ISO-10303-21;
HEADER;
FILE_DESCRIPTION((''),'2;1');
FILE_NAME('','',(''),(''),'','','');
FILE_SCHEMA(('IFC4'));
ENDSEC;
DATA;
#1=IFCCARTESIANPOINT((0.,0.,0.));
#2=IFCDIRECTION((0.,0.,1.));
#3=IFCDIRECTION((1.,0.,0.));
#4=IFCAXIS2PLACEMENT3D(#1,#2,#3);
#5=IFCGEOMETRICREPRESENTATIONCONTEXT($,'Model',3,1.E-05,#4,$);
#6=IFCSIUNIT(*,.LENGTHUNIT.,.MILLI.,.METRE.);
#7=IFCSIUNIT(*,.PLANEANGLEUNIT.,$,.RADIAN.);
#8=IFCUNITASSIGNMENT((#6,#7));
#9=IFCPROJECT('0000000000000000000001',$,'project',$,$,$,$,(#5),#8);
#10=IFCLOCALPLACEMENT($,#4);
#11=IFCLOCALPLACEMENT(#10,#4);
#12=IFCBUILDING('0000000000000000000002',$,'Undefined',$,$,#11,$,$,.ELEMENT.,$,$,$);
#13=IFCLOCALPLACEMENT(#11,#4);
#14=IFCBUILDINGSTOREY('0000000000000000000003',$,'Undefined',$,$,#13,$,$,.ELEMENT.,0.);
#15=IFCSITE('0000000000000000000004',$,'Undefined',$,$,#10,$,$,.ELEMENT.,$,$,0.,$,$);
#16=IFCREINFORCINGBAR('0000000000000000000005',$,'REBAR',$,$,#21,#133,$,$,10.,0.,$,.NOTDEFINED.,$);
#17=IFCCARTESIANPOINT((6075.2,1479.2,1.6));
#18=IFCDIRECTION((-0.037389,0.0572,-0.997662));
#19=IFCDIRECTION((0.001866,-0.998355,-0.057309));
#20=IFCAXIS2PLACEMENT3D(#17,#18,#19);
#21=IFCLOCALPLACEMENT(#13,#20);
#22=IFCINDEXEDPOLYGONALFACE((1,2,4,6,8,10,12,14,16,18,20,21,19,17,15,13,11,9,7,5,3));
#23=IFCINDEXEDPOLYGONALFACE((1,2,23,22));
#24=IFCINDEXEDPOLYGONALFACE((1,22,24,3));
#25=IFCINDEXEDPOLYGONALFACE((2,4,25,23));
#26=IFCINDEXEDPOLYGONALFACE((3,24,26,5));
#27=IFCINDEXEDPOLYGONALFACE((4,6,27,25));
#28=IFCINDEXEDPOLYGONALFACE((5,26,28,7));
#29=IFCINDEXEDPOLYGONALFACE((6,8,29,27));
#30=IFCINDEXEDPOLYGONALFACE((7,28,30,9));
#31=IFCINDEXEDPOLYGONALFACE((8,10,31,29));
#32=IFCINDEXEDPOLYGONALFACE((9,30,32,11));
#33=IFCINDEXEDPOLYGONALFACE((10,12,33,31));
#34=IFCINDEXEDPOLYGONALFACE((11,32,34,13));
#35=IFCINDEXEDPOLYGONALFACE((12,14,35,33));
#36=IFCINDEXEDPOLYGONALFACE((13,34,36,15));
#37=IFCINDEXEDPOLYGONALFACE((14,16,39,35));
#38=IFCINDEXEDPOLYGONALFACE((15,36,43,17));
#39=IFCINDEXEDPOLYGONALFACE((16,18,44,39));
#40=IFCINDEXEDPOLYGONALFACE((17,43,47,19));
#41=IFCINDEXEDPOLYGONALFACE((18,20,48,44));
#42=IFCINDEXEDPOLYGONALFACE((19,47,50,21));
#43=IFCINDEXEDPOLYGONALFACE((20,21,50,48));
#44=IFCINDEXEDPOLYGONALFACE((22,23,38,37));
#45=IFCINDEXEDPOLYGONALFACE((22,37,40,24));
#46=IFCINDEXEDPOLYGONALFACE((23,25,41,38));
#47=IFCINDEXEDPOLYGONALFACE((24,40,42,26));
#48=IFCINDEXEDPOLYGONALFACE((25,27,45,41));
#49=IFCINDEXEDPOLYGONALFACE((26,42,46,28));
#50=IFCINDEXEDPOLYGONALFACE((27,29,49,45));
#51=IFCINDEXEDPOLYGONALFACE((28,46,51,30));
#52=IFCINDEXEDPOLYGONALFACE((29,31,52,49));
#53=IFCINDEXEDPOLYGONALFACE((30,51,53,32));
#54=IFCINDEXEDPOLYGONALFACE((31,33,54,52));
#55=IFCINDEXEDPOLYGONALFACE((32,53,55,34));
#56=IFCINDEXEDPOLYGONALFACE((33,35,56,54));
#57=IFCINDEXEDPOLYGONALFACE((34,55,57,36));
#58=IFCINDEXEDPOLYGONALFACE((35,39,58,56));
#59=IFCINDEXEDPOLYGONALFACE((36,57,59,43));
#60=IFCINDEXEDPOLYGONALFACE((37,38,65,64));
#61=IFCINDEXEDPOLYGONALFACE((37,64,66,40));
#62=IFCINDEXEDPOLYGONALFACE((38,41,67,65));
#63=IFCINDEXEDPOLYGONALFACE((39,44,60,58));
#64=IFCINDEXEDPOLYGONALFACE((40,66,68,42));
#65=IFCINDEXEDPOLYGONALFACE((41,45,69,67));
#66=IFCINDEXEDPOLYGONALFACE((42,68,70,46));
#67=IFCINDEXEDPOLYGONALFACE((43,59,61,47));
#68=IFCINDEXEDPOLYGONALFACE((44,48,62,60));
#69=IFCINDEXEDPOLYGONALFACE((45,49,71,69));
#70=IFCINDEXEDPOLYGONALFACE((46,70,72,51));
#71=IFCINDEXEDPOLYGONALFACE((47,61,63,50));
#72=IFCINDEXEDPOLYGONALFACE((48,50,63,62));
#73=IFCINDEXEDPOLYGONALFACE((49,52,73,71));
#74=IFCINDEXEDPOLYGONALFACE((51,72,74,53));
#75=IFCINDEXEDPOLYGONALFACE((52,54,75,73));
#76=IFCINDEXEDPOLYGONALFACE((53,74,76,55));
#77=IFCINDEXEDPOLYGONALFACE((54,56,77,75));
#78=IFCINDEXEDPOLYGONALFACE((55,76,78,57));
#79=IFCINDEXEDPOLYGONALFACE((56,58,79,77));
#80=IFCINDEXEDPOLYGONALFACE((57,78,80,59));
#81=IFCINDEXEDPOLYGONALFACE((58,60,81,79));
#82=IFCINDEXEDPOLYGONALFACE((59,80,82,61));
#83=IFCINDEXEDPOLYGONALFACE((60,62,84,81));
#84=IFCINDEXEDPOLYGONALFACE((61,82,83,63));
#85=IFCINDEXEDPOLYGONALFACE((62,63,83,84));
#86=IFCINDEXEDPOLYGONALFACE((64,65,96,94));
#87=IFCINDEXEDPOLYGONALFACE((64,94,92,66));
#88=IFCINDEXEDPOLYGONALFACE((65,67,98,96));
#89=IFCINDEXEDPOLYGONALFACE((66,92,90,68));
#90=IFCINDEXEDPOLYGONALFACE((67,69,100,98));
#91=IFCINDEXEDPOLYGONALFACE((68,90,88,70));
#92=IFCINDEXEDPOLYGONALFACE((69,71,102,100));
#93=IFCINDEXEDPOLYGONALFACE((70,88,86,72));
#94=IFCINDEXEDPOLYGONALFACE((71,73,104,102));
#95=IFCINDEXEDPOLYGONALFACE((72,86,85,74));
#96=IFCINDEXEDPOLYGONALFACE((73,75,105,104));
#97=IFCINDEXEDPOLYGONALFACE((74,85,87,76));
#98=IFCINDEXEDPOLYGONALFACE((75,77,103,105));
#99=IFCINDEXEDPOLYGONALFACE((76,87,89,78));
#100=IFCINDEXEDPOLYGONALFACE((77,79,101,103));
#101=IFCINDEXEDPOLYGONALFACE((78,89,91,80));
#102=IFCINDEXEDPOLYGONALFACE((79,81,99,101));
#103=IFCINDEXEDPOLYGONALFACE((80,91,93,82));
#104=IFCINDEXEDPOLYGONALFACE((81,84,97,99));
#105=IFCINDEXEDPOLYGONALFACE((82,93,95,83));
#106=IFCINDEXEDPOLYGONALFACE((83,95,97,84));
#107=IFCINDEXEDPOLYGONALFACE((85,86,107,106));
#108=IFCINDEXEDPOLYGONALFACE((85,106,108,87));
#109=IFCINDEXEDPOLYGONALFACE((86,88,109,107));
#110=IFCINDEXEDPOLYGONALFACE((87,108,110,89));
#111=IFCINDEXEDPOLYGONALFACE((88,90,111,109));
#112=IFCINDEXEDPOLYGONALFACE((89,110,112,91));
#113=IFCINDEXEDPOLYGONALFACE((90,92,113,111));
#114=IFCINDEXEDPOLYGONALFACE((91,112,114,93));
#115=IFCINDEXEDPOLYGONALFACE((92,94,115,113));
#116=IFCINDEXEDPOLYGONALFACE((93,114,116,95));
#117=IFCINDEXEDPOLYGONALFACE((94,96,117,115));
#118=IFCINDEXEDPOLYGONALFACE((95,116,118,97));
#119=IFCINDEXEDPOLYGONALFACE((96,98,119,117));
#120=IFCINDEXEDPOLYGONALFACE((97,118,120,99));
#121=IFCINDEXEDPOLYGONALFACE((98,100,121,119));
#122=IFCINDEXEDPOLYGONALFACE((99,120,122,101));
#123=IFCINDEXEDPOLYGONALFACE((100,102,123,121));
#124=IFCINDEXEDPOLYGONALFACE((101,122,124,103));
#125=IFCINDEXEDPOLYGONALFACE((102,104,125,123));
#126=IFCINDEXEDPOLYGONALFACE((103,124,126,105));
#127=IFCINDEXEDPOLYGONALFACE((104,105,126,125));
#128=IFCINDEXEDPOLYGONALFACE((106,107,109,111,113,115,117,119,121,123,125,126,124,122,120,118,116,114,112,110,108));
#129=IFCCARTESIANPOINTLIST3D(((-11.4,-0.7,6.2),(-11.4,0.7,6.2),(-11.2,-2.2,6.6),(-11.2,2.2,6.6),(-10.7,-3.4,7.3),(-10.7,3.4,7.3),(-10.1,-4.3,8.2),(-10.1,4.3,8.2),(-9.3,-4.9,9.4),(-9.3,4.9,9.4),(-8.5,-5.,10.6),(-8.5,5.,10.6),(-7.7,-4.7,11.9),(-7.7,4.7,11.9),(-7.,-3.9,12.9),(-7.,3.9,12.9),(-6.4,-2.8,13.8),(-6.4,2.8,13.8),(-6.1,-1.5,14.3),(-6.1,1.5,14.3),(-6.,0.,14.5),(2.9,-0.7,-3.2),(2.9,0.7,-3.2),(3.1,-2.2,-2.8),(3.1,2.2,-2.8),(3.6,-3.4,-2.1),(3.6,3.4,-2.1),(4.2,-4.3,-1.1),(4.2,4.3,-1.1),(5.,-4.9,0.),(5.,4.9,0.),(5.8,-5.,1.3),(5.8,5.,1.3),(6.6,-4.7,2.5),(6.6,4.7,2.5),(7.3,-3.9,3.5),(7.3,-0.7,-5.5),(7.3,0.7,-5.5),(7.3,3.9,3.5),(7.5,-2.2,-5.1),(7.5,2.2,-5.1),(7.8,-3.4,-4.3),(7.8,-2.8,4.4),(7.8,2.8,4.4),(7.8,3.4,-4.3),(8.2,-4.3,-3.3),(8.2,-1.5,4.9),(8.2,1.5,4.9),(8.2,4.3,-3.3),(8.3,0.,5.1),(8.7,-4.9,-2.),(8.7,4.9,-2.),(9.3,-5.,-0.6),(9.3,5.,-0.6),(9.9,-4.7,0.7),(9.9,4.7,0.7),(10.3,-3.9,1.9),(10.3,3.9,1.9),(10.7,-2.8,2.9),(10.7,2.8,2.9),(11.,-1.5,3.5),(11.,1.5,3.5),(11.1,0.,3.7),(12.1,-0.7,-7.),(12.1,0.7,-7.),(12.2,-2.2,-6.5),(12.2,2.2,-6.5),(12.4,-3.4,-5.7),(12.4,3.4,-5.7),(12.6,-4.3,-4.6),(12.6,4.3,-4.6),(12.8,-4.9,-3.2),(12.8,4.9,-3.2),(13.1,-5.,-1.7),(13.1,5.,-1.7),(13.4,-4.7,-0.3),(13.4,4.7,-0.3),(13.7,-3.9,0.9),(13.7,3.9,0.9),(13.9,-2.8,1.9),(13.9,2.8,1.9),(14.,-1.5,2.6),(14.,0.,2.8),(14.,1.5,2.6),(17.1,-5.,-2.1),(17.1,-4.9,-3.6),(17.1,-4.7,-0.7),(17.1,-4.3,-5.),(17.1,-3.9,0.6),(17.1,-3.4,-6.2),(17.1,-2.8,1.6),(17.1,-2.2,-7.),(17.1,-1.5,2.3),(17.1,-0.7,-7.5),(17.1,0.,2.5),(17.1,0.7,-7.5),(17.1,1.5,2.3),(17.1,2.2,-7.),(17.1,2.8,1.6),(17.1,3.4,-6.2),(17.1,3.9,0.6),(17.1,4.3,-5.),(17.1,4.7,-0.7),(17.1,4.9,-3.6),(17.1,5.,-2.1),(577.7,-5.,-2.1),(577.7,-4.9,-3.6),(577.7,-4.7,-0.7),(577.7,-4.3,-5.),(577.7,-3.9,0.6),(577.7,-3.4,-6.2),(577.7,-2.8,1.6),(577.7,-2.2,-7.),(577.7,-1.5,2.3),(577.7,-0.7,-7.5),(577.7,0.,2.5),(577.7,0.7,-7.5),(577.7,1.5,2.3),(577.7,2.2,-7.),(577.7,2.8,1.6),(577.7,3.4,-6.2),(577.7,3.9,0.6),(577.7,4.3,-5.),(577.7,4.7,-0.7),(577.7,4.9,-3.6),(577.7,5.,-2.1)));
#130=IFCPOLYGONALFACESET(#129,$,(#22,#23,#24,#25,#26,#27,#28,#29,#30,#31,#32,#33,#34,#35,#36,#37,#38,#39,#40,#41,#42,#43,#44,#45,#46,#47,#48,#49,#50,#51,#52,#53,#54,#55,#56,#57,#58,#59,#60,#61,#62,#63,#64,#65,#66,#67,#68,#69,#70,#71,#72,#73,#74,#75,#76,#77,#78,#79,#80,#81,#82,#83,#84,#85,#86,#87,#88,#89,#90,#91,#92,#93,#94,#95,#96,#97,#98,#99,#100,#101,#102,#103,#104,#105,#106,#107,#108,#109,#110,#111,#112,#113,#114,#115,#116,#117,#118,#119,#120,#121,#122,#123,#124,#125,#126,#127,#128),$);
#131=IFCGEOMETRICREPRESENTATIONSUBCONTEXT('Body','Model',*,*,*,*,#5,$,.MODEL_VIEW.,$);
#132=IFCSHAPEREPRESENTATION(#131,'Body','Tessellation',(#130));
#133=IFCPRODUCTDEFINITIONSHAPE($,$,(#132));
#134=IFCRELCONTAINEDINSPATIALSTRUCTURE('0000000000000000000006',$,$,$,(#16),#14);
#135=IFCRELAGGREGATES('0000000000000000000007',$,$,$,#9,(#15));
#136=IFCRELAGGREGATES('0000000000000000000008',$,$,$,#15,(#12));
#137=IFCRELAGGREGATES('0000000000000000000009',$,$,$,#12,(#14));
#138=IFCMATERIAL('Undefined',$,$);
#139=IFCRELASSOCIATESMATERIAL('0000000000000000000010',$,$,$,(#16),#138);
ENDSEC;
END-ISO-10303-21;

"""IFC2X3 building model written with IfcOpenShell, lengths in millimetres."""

from ifc_helpers import new_model, entity, si_unit, frame, origin_with_axes, place, context, subcontext, project, spatial, source, transform, mapped, material, element, save


model = new_model("IFC2X3")

# Units and contexts
model_context = context("Model", 3, precision=1e-05, world=origin_with_axes())
body_context = subcontext(model_context, "Body", "Model", "MODEL_VIEW")
ifc_project = project(units=[si_unit("LENGTHUNIT", "METRE", prefix="MILLI"), si_unit("PLANEANGLEUNIT", "RADIAN")], contexts=[model_context])

# Site, building, storey
site_placement = place(None, origin_with_axes())
site = spatial("IfcSite", under=ifc_project, at=site_placement, Name="Undefined", CompositionType="ELEMENT", RefElevation=0.0)
building_placement = place(site_placement, origin_with_axes())
building = spatial("IfcBuilding", under=site, at=building_placement, Name="Undefined", CompositionType="ELEMENT")
storey_placement = place(building_placement, origin_with_axes())
storey = spatial("IfcBuildingStorey", under=building, at=storey_placement, Name="Undefined", CompositionType="ELEMENT", Elevation=0.0)

# Reinforcing bar
ifc_material_1 = material(Name="Undefined")
shared_shape_1 = source(origin_with_axes(), body_context, "Body", "AdvancedSweptSolid", [
    entity("IfcSweptDiskSolid", entity("IfcCompositeCurve", [entity("IfcCompositeCurveSegment", "CONTINUOUS", True, entity("IfcTrimmedCurve", entity("IfcLine", entity("IfcCartesianPoint", [0.0, 0.0, 0.0]), entity("IfcVector", entity("IfcDirection", [0.835483, 0.0, -0.549516]), 1.0)), [entity("IfcParameterValue", 0.0)], [entity("IfcParameterValue", 17.082101)], True, "PARAMETER")), entity("IfcCompositeCurveSegment", "CONTINUOUS", True, entity("IfcTrimmedCurve", entity("IfcCircle", entity("IfcAxis2Placement3D", entity("IfcCartesianPoint", [25.8, 0.0, 8.2]), entity("IfcDirection", [0.0, -1.0, 0.0]), entity("IfcDirection", [-0.549516, 0.0, -0.835483])), 21.0), [entity("IfcParameterValue", 0.0)], [entity("IfcParameterValue", 0.581785)], True, "PARAMETER")), entity("IfcCompositeCurveSegment", "DISCONTINUOUS", True, entity("IfcTrimmedCurve", entity("IfcLine", entity("IfcCartesianPoint", [25.8, 0.0, -12.8]), entity("IfcVector", entity("IfcDirection", [1.0, 0.0, 0.0]), 1.0)), [entity("IfcParameterValue", 0.0)], [entity("IfcParameterValue", 560.593055)], True, "PARAMETER"))], False), 5.0, None, 0.0, 578.3),
])
reinforcing_bar_1_placement = place(storey_placement, frame((6075.2, 1479.2, 1.6), z_axis=(-0.037389, 0.0572, -0.997662), x_axis=(0.001866, -0.998355, -0.057309)))
element("IfcReinforcingBar", 1, at=reinforcing_bar_1_placement, inside=storey, material=ifc_material_1, Name="REBAR", BarRole="NOTDEFINED", CrossSectionArea=0.0, NominalDiameter=10.0, context=body_context, shape_type="MappedRepresentation", body=[
    mapped(shared_shape_1, transform((-8.7, 0.0, 10.3))),
])

save(model, "model.ifc")
